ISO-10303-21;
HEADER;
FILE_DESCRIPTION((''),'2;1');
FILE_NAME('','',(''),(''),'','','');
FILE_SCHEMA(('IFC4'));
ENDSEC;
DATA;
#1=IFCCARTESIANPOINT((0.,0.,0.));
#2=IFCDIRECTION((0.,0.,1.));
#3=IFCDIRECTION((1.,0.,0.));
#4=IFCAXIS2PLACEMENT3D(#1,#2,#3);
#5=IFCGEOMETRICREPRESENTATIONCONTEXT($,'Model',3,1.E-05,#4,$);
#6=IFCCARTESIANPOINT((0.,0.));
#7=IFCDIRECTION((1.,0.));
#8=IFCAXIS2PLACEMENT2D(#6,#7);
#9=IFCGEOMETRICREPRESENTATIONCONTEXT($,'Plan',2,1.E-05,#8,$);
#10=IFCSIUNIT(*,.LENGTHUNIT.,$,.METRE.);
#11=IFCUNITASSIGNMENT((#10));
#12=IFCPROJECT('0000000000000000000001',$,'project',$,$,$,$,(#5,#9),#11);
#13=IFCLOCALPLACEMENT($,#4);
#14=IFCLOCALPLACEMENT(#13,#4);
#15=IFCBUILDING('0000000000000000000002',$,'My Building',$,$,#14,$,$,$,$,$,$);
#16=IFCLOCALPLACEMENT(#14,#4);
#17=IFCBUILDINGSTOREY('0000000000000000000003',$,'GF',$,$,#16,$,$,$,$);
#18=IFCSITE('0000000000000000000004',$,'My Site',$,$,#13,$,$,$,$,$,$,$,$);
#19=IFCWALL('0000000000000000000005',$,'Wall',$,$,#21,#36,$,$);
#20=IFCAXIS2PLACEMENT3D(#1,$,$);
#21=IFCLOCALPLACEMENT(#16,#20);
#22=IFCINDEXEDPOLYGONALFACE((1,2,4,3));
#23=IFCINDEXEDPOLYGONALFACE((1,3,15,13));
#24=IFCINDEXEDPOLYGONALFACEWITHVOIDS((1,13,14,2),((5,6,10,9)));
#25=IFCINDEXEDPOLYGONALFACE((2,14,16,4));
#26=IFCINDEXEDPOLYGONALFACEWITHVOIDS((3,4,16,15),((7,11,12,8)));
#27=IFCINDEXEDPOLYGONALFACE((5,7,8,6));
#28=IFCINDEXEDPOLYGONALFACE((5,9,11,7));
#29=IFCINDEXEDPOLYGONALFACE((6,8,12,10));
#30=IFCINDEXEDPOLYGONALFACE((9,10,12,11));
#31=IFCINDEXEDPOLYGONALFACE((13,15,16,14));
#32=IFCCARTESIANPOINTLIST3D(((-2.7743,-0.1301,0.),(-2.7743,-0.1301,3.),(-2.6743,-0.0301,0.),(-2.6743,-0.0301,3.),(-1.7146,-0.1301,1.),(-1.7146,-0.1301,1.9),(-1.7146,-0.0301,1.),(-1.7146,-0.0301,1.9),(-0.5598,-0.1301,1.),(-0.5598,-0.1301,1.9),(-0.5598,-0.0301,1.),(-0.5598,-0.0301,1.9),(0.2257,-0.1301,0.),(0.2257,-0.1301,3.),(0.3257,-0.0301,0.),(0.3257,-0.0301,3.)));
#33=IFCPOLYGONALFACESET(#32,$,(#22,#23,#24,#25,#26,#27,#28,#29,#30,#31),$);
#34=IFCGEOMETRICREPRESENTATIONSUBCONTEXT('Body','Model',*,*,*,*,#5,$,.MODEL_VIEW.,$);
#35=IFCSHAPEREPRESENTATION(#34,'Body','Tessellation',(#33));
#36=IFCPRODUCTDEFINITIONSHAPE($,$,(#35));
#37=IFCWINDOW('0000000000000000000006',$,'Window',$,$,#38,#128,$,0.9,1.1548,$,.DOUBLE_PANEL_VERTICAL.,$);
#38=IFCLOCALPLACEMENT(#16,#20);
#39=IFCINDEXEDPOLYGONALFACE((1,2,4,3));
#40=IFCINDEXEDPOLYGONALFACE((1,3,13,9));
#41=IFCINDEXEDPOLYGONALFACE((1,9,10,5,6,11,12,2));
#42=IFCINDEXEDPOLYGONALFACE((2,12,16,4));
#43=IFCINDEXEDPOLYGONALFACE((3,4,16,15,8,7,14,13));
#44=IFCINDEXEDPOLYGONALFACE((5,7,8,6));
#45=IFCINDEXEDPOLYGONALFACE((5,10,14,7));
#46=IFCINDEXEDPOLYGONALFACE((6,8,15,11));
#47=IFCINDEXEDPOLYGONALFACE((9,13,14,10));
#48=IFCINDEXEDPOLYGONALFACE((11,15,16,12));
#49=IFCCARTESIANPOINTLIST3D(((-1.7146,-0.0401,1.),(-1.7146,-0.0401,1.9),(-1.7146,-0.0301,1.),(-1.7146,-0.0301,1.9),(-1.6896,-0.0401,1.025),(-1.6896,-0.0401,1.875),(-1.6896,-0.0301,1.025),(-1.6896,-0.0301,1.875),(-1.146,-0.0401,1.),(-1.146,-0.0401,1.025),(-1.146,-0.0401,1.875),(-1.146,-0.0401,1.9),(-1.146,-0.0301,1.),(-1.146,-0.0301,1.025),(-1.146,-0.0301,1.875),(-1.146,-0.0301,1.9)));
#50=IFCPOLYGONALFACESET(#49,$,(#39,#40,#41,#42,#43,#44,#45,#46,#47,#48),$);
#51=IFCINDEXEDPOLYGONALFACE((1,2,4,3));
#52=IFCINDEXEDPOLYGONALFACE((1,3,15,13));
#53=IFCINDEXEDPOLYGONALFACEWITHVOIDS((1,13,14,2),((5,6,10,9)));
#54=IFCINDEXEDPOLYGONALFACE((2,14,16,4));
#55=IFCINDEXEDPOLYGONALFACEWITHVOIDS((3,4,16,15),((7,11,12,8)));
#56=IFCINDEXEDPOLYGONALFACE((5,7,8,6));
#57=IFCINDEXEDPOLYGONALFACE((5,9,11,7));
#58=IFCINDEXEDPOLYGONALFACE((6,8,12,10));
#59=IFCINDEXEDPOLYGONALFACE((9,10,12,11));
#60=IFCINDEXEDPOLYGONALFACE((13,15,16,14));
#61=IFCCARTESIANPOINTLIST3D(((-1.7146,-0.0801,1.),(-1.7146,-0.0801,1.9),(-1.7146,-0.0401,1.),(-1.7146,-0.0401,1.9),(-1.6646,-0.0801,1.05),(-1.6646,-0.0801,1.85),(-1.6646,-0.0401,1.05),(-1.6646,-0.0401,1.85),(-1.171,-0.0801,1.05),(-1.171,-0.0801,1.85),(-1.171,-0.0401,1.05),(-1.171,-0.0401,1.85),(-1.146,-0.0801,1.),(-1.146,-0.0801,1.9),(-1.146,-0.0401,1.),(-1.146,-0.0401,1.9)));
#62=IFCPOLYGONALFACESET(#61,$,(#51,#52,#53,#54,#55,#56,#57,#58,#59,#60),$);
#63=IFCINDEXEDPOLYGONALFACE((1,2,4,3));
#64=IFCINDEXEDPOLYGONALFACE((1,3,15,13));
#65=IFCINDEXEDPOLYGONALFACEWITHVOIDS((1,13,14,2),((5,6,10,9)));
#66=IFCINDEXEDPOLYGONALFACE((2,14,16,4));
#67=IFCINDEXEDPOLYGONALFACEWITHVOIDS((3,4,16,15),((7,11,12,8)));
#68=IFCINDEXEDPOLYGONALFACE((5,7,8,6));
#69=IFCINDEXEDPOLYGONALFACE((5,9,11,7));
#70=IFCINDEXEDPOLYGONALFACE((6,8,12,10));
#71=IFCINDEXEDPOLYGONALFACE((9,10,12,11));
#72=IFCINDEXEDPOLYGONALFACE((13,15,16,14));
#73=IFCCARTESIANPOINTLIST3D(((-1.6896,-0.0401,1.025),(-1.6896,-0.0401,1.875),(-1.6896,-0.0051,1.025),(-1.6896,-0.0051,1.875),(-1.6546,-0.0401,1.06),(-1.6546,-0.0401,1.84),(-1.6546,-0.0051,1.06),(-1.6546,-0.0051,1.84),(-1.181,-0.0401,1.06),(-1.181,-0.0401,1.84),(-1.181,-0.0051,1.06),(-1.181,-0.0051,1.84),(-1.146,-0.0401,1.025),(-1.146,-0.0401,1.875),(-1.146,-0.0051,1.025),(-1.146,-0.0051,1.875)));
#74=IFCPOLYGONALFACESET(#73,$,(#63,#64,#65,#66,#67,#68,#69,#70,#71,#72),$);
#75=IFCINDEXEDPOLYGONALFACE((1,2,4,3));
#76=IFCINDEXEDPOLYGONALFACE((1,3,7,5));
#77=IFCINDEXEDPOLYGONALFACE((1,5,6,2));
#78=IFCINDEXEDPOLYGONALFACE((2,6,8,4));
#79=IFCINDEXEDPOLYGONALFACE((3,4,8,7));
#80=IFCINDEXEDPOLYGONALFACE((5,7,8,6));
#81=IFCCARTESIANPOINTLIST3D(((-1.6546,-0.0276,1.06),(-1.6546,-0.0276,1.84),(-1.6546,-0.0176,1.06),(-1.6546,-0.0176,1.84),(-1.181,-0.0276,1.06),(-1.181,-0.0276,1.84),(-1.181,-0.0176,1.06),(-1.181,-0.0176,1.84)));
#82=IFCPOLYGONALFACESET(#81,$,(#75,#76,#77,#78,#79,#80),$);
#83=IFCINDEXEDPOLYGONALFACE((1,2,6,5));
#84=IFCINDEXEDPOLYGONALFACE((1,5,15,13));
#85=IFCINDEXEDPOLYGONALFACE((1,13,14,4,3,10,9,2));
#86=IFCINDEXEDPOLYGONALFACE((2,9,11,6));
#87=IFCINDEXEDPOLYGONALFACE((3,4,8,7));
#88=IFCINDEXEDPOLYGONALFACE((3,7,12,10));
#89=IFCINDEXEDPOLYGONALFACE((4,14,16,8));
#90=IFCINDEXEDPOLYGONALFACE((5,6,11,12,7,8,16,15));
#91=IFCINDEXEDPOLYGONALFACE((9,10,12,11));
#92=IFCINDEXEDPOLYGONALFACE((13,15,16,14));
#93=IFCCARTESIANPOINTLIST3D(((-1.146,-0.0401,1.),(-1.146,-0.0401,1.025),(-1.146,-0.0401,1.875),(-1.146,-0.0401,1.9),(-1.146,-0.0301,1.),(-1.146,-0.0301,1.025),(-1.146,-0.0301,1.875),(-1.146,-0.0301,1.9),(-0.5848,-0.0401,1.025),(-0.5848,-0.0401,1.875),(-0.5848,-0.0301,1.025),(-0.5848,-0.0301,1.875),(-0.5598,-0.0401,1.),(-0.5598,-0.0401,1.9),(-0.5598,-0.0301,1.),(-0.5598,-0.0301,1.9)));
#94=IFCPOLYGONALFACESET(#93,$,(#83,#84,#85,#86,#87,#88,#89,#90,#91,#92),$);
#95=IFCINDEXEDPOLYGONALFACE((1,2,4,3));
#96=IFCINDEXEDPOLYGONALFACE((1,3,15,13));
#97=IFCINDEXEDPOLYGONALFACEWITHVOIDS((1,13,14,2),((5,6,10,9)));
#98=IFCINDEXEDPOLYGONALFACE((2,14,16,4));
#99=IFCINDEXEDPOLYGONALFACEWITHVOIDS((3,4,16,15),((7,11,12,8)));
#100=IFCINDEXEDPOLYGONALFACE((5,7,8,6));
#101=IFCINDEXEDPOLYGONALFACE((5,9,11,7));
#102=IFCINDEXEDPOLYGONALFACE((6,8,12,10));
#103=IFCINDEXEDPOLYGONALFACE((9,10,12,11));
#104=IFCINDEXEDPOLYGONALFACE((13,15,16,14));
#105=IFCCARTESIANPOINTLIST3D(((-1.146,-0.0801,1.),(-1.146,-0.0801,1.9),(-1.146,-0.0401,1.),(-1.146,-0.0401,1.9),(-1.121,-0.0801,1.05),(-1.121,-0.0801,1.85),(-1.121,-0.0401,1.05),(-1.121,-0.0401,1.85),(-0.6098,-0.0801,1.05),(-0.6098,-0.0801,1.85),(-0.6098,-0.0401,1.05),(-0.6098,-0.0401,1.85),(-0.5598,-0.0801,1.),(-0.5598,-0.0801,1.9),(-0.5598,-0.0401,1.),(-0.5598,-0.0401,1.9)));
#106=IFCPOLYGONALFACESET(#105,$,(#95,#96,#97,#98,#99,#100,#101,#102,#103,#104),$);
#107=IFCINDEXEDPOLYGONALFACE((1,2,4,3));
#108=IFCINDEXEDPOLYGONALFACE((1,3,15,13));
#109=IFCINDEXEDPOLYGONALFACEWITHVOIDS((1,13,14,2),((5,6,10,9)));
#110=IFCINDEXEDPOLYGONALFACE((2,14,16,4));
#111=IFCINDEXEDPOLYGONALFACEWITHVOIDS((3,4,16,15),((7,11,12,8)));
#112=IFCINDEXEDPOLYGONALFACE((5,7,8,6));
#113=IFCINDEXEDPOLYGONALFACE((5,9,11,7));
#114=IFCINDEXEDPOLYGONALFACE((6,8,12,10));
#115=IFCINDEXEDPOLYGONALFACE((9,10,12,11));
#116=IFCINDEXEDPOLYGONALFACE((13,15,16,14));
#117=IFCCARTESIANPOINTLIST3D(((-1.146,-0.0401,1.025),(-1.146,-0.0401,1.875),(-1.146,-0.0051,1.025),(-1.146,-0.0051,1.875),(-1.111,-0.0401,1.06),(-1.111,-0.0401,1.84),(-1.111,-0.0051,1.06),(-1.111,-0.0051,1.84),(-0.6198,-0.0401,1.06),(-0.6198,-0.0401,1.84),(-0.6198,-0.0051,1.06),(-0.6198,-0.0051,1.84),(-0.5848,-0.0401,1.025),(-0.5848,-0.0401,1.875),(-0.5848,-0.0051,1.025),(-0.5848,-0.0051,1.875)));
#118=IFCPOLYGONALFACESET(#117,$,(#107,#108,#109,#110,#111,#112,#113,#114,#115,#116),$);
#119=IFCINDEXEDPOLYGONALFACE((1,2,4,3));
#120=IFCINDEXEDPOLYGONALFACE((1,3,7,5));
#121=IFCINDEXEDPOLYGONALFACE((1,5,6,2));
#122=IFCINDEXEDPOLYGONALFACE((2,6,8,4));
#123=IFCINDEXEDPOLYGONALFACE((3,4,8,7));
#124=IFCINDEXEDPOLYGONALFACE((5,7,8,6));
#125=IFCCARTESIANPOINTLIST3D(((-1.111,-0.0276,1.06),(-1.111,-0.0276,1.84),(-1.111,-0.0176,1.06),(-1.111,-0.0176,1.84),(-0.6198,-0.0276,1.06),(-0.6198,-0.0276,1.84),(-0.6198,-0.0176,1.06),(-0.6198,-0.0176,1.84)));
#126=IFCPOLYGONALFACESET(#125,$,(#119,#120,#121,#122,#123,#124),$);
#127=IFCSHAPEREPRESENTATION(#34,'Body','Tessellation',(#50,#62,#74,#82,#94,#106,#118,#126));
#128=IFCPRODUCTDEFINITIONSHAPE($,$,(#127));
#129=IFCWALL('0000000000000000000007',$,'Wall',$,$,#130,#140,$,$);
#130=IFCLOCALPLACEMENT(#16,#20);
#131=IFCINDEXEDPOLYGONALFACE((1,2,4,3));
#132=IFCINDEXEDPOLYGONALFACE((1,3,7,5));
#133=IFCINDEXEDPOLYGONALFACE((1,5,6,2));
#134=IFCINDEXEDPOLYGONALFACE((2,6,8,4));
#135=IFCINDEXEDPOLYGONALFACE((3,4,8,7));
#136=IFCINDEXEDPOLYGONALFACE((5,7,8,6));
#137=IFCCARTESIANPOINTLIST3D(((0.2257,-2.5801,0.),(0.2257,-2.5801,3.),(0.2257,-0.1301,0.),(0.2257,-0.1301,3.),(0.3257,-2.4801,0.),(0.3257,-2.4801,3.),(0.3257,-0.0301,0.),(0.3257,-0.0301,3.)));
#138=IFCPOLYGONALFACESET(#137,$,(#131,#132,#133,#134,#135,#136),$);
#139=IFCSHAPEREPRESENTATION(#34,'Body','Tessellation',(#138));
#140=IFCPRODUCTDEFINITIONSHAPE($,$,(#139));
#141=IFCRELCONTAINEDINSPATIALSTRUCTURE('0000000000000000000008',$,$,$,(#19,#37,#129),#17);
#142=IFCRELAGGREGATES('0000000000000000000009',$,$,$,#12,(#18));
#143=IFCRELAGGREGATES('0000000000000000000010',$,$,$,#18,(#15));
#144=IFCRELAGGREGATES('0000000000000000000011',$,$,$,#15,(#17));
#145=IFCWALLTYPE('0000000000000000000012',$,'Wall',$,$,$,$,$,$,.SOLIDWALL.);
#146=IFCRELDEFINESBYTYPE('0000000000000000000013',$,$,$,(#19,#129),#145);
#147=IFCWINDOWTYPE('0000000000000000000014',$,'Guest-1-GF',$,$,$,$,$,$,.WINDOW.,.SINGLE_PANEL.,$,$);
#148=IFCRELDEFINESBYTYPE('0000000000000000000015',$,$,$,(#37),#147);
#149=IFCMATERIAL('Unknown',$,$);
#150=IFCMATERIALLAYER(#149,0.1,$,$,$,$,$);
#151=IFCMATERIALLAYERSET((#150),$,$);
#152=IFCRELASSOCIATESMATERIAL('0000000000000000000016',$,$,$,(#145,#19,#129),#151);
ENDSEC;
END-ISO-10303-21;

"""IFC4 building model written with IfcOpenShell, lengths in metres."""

from ifc_helpers import new_model, entity, si_unit, frame, origin_with_axes, origin_2d_with_axis, place, context, subcontext, project, spatial, line, indexed_curve, outline, extrude, shape, source, transform, mapped, material, layer, layer_set, layer_usage, type_object, type_shapes, element, fill, save


model = new_model("IFC4")

# Units and contexts
model_context = context("Model", 3, precision=1e-05, world=origin_with_axes())
plan_context = context("Plan", 2, precision=1e-05, world=origin_2d_with_axis())
body_context_1 = subcontext(model_context, "Body", "Model", "MODEL_VIEW")
body_context_2 = subcontext(plan_context, "Body", "Plan", "PLAN_VIEW")
ifc_project = project(units=[si_unit("LENGTHUNIT", "METRE")], contexts=[model_context, plan_context])

# Site, building, storey
site_placement = place(None, origin_with_axes())
site = spatial("IfcSite", under=ifc_project, at=site_placement, Name="My Site")
building_placement = place(site_placement, origin_with_axes())
building = spatial("IfcBuilding", under=site, at=building_placement, Name="My Building")
storey_placement = place(building_placement, origin_with_axes())
storey = spatial("IfcBuildingStorey", under=building, at=storey_placement, Name="GF")

# Shared definitions
ifc_material = material(Name="Unknown")

# Shared definitions
ifc_layer_1 = layer(ifc_material, 0.1)
ifc_layer_set_1 = layer_set([ifc_layer_1])
wall_type = type_object("IfcWallType", Name="Wall", PredefinedType="SOLIDWALL", material=ifc_layer_set_1)

# Wall, opening, window
ifc_layer_usage_1 = layer_usage(ifc_layer_set_1, "AXIS2", "POSITIVE", 0.0)
wall_1_placement = place(storey_placement, frame((-2.7743, -0.1301, 0.0), z_axis=(0.0, 0.0, 1.0), x_axis=(1.0, 0.0, 0.0)))
wall_1 = element("IfcWall", 1, at=wall_1_placement, inside=storey, type_object=wall_type, material=ifc_layer_usage_1, Name="Wall", context=body_context_1, shape_type="SweptSolid", body=[
    extrude(outline(indexed_curve([(0.0, 0.0), (0.1, 0.1), (3.1, 0.1), (3.0, 0.0)], segments=[line(1, 2, 3, 4, 1)])), origin_with_axes(), (0.0, 0.0, 1.0), 3.0),
])
shared_shape_1 = source(origin_with_axes(), body_context_1, "Body", "SweptSolid", [
    extrude(outline(indexed_curve([(0.0, 0.0), (1.1548, 0.0), (1.1548, 0.9), (0.0, 0.9)], segments=[line(1, 2, 3, 4, 1)])), frame((0.0, -0.6, 0.0), z_axis=(0.0, -1.0, 0.0), x_axis=(1.0, 0.0, 0.0)), (0.0, 0.0, -1.0), 1.2),
])
opening_1_placement = place(wall_1_placement, frame((1.0596, 0.0, 1.0), z_axis=(0.0, 0.0, 1.0), x_axis=(1.0, 0.0, 0.0)))
opening_1 = element("IfcOpeningElement", 2, at=opening_1_placement, cuts=wall_1, PredefinedType="OPENING", context=body_context_1, shape_type="MappedRepresentation", body=[
    mapped(shared_shape_1, transform((0.0, 0.0, 0.0), x_axis=(1.0, 0.0, 0.0), y_axis=(0.0, 1.0, 0.0), z_axis=(0.0, 0.0, 1.0), scale=1.0)),
])
window_type_1 = type_object("IfcWindowType", Name="Guest-1-GF", PartitioningType="SINGLE_PANEL", PredefinedType="WINDOW")
shared_shape_2 = source(origin_with_axes(), body_context_1, "Body", "SweptSolid", [
    extrude(outline(indexed_curve([(0.5686, 0.0), (0.0, 0.0), (0.0, 0.9), (0.5686, 0.9), (0.5686, 0.875), (0.025, 0.875), (0.025, 0.025), (0.5686, 0.025)], segments=[line(1, 2, 3, 4, 5, 6, 7, 8, 1)])), frame((0.0, 0.09, 0.0), z_axis=(0.0, -1.0, 0.0), x_axis=(1.0, 0.0, 0.0)), (0.0, 0.0, -1.0), 0.01),
    extrude(outline(indexed_curve([(0.0, 0.0), (0.5686, 0.0), (0.5686, 0.9), (0.0, 0.9)], segments=[line(1, 2, 3, 4, 1)]), holes=[indexed_curve([(0.05, 0.05), (0.5436, 0.05), (0.5436, 0.85), (0.05, 0.85)], segments=[line(1, 2, 3, 4, 1)])]), frame((0.0, 0.05, 0.0), z_axis=(0.0, -1.0, 0.0), x_axis=(1.0, 0.0, 0.0)), (0.0, 0.0, -1.0), 0.04),
    extrude(outline(indexed_curve([(0.0, 0.0), (0.5436, 0.0), (0.5436, 0.85), (0.0, 0.85)], segments=[line(1, 2, 3, 4, 1)]), holes=[indexed_curve([(0.035, 0.035), (0.5086, 0.035), (0.5086, 0.815), (0.035, 0.815)], segments=[line(1, 2, 3, 4, 1)])]), frame((0.025, 0.09, 0.025), z_axis=(0.0, -1.0, 0.0), x_axis=(1.0, 0.0, 0.0)), (0.0, 0.0, -1.0), 0.035),
    extrude(outline(indexed_curve([(0.035, 0.035), (0.5086, 0.035), (0.5086, 0.815), (0.035, 0.815)], segments=[line(1, 2, 3, 4, 1)])), frame((0.025, 0.1025, 0.025), z_axis=(0.0, -1.0, 0.0), x_axis=(1.0, 0.0, 0.0)), (0.0, 0.0, -1.0), 0.01),
    extrude(outline(indexed_curve([(0.0, 0.9), (0.5862, 0.9), (0.5862, 0.0), (0.0, 0.0), (0.0, 0.025), (0.5612, 0.025), (0.5612, 0.875), (0.0, 0.875)], segments=[line(1, 2, 3, 4, 5, 6, 7, 8, 1)])), frame((0.5686, 0.09, 0.0), z_axis=(0.0, -1.0, 0.0), x_axis=(1.0, 0.0, 0.0)), (0.0, 0.0, -1.0), 0.01),
    extrude(outline(indexed_curve([(0.0, 0.0), (0.5862, 0.0), (0.5862, 0.9), (0.0, 0.9)], segments=[line(1, 2, 3, 4, 1)]), holes=[indexed_curve([(0.025, 0.05), (0.5362, 0.05), (0.5362, 0.85), (0.025, 0.85)], segments=[line(1, 2, 3, 4, 1)])]), frame((0.5686, 0.05, 0.0), z_axis=(0.0, -1.0, 0.0), x_axis=(1.0, 0.0, 0.0)), (0.0, 0.0, -1.0), 0.04),
    extrude(outline(indexed_curve([(0.0, 0.0), (0.5612, 0.0), (0.5612, 0.85), (0.0, 0.85)], segments=[line(1, 2, 3, 4, 1)]), holes=[indexed_curve([(0.035, 0.035), (0.5262, 0.035), (0.5262, 0.815), (0.035, 0.815)], segments=[line(1, 2, 3, 4, 1)])]), frame((0.5686, 0.09, 0.025), z_axis=(0.0, -1.0, 0.0), x_axis=(1.0, 0.0, 0.0)), (0.0, 0.0, -1.0), 0.035),
    extrude(outline(indexed_curve([(0.035, 0.035), (0.5262, 0.035), (0.5262, 0.815), (0.035, 0.815)], segments=[line(1, 2, 3, 4, 1)])), frame((0.5686, 0.1025, 0.025), z_axis=(0.0, -1.0, 0.0), x_axis=(1.0, 0.0, 0.0)), (0.0, 0.0, -1.0), 0.01),
])
shared_shape_3 = source(origin_with_axes(), body_context_2, "Body", "Curve2D", [
    entity("IfcIndexedPolyCurve", entity("IfcCartesianPointList2D", [[0.05, 0.05], [0.5436, 0.05]])),
    entity("IfcIndexedPolyCurve", entity("IfcCartesianPointList2D", [[0.0, 0.1], [0.025, 0.1], [0.025, 0.09], [0.05, 0.09], [0.05, 0.05], [0.0, 0.05]]), [entity("IfcLineIndex", [1, 2, 3, 4, 5, 6, 1])]),
    entity("IfcIndexedPolyCurve", entity("IfcCartesianPointList2D", [[0.5686, 0.1], [0.5686, 0.1], [0.5686, 0.09], [0.5436, 0.09], [0.5436, 0.05], [0.5686, 0.05]])),
    entity("IfcIndexedPolyCurve", entity("IfcCartesianPointList2D", [[0.025, 0.09], [0.06, 0.09], [0.06, 0.125], [0.025, 0.125]]), [entity("IfcLineIndex", [1, 2, 3, 4, 1])]),
    entity("IfcIndexedPolyCurve", entity("IfcCartesianPointList2D", [[0.5686, 0.09], [0.5336, 0.09], [0.5336, 0.125], [0.5686, 0.125]]), [entity("IfcLineIndex", [1, 2, 3, 4, 1])]),
    entity("IfcIndexedPolyCurve", entity("IfcCartesianPointList2D", [[0.06, 0.09], [0.5336, 0.09]])),
    entity("IfcIndexedPolyCurve", entity("IfcCartesianPointList2D", [[0.06, 0.125], [0.5336, 0.125]])),
    entity("IfcIndexedPolyCurve", entity("IfcCartesianPointList2D", [[0.06, 0.1075], [0.5336, 0.1075]])),
    entity("IfcIndexedPolyCurve", entity("IfcCartesianPointList2D", [[0.5936, 0.05], [1.1048, 0.05]])),
    entity("IfcIndexedPolyCurve", entity("IfcCartesianPointList2D", [[0.5686, 0.1], [0.5686, 0.1], [0.5686, 0.09], [0.5936, 0.09], [0.5936, 0.05], [0.5686, 0.05]])),
    entity("IfcIndexedPolyCurve", entity("IfcCartesianPointList2D", [[1.1548, 0.1], [1.1298, 0.1], [1.1298, 0.09], [1.1048, 0.09], [1.1048, 0.05], [1.1548, 0.05]]), [entity("IfcLineIndex", [1, 2, 3, 4, 5, 6, 1])]),
    entity("IfcIndexedPolyCurve", entity("IfcCartesianPointList2D", [[0.5686, 0.09], [0.6036, 0.09], [0.6036, 0.125], [0.5686, 0.125]]), [entity("IfcLineIndex", [1, 2, 3, 4, 1])]),
    entity("IfcIndexedPolyCurve", entity("IfcCartesianPointList2D", [[1.1298, 0.09], [1.0948, 0.09], [1.0948, 0.125], [1.1298, 0.125]]), [entity("IfcLineIndex", [1, 2, 3, 4, 1])]),
    entity("IfcIndexedPolyCurve", entity("IfcCartesianPointList2D", [[0.6036, 0.09], [1.0948, 0.09]])),
    entity("IfcIndexedPolyCurve", entity("IfcCartesianPointList2D", [[0.6036, 0.125], [1.0948, 0.125]])),
    entity("IfcIndexedPolyCurve", entity("IfcCartesianPointList2D", [[0.6036, 0.1075], [1.0948, 0.1075]])),
])
type_shapes(window_type_1, [shared_shape_2, shared_shape_3])
window_1_placement = place(opening_1_placement, origin_with_axes())
window_1 = element("IfcWindow", 3, at=window_1_placement, inside=storey, type_object=window_type_1, Name="Window", OverallHeight=0.9, OverallWidth=1.1548, PartitioningType="DOUBLE_PANEL_VERTICAL", shapes=[
    shape(body_context_1, "Body", "MappedRepresentation", [mapped(shared_shape_2, transform((0.0, 0.0, 0.0), x_axis=(1.0, 0.0, 0.0), y_axis=(0.0, 1.0, 0.0), z_axis=(0.0, 0.0, 1.0), scale=1.0))]),
    shape(body_context_2, "Body", "MappedRepresentation", [mapped(shared_shape_3, transform((0.0, 0.0, 0.0), x_axis=(1.0, 0.0, 0.0), y_axis=(0.0, 1.0, 0.0), z_axis=(0.0, 0.0, 1.0), scale=1.0))]),
])
fill(opening_1, window_1)

# Wall
ifc_layer_usage_2 = layer_usage(ifc_layer_set_1, "AXIS2", "POSITIVE", 0.0)
wall_2_placement = place(storey_placement, frame((0.2257, -0.1301, 0.0), z_axis=(0.0, 0.0, 1.0), x_axis=(-0.000001, -1.0, 0.0)))
element("IfcWall", 4, at=wall_2_placement, inside=storey, type_object=wall_type, material=ifc_layer_usage_2, Name="Wall", context=body_context_1, shape_type="SweptSolid", body=[
    extrude(outline(indexed_curve([(0.0, 0.0), (-0.1, 0.1), (2.35, 0.1), (2.45, 0.0)], segments=[line(1, 2, 3, 4, 1)])), origin_with_axes(), (0.0, 0.0, 1.0), 3.0),
])

save(model, "model.ifc")
